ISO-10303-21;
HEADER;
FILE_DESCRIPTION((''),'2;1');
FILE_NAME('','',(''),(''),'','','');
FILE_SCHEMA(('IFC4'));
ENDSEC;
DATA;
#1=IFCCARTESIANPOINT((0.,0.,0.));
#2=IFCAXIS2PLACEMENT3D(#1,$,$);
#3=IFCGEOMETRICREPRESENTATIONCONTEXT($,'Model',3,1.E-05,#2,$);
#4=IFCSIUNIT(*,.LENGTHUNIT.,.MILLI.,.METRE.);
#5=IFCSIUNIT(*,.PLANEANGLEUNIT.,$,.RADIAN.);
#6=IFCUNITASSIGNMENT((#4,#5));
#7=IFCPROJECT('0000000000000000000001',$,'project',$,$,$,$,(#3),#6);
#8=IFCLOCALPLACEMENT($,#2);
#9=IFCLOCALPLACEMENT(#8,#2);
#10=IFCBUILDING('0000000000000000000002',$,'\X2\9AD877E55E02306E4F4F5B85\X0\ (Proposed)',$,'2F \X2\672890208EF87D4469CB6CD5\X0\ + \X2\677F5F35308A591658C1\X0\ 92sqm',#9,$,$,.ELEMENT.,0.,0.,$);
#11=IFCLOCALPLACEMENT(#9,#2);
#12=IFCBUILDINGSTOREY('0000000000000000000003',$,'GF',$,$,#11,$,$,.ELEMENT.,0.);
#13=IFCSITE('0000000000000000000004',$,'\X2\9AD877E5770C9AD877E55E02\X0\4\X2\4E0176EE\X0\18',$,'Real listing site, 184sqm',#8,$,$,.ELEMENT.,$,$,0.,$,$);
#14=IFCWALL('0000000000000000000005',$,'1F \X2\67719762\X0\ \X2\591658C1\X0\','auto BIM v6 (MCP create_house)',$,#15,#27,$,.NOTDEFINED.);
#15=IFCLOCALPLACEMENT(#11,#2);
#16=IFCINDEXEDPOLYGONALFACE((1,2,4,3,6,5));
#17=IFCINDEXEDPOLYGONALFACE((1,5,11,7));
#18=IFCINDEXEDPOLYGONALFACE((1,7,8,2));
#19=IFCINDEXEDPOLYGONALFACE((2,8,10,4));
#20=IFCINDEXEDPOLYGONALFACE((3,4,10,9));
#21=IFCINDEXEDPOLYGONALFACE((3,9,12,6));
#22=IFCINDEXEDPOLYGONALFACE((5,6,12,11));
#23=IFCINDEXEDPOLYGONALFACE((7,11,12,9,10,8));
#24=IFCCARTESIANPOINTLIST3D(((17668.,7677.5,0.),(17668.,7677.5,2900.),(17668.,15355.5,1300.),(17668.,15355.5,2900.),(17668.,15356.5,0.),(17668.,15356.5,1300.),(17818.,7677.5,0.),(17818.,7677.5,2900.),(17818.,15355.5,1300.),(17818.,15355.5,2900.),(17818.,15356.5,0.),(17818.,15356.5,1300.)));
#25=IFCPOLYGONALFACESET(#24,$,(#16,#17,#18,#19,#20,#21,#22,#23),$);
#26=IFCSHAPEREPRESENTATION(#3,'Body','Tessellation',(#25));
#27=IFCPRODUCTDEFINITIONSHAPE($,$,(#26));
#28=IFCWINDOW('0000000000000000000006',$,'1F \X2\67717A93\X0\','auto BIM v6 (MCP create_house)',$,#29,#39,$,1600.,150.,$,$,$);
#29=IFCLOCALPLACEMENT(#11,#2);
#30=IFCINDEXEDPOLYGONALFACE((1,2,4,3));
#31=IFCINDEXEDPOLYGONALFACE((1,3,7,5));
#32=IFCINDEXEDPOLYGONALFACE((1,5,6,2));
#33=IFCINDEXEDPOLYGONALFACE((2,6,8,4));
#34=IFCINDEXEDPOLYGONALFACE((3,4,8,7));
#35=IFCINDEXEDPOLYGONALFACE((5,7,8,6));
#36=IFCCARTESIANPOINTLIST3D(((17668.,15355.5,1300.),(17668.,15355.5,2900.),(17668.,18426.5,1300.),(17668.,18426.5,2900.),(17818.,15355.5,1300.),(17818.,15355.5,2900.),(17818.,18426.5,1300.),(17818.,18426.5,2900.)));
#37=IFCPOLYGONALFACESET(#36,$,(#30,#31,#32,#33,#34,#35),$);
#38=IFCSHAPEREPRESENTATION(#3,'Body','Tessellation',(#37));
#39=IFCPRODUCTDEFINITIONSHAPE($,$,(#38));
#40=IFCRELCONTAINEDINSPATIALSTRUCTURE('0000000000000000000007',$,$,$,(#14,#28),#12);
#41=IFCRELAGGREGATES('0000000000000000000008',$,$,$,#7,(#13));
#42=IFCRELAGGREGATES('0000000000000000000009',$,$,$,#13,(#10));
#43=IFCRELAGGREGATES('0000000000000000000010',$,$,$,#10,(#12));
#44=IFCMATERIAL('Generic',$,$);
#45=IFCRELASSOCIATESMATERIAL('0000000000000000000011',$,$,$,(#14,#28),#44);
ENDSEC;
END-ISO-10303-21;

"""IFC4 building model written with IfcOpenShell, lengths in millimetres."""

from ifc_helpers import new_model, si_unit, frame, frame_2d, origin, place, context, project, spatial, rectangle, extrude, material, element, fill, save


model = new_model("IFC4")

# Units and contexts
model_context = context("Model", 3, precision=1e-05, world=origin())
ifc_project = project(units=[si_unit("LENGTHUNIT", "METRE", prefix="MILLI"), si_unit("PLANEANGLEUNIT", "RADIAN")], contexts=[model_context])

# Site, building, storey
site_placement = place(None, origin())
site = spatial("IfcSite", under=ifc_project, at=site_placement, Name="高知県高知市4丁目18", ObjectType="Real listing site, 184sqm", CompositionType="ELEMENT", RefElevation=0.0)
building_placement = place(site_placement, origin())
building = spatial("IfcBuilding", under=site, at=building_placement, Name="高知市の住宅 (Proposed)", ObjectType="2F 木造軸組構法 + 板張り外壁 92sqm", CompositionType="ELEMENT", ElevationOfRefHeight=0.0, ElevationOfTerrain=0.0)
storey_placement = place(building_placement, origin())
storey = spatial("IfcBuildingStorey", under=building, at=storey_placement, Name="GF", CompositionType="ELEMENT", Elevation=0.0)

# Shared definitions
ifc_material = material(Name="Generic")

# Wall, opening, window
wall_1_placement = place(storey_placement, frame((8834.0, 3839.0, 0.0)))
wall_1 = element("IfcWall", 1, at=wall_1_placement, inside=storey, material=ifc_material, Name="1F 東面 外壁", Description="auto BIM v6 (MCP create_house)", PredefinedType="NOTDEFINED", context=model_context, shape_type="SweptSolid", body=[
    extrude(rectangle(XDim=150.0, YDim=7679.0, at=frame_2d((75.0, 3839.0))), frame((8834.0, 3839.0, 0.0)), (0.0, 0.0, 1.0), 2900.0),
])
opening_1_placement = place(storey_placement, frame((8834.0, 7678.0, 650.0)))
opening_1 = element("IfcOpeningElement", 2, at=opening_1_placement, cuts=wall_1, PredefinedType="NOTDEFINED", context=model_context, shape_type="SweptSolid", body=[
    extrude(rectangle(XDim=150.0, YDim=3071.0, at=frame_2d((75.0, 1535.0))), frame((8834.0, 7678.0, 650.0)), (0.0, 0.0, 1.0), 1600.0),
])
window_1_placement = place(storey_placement, frame((8834.0, 7678.0, 650.0)))
window_1 = element("IfcWindow", 3, at=window_1_placement, inside=storey, material=ifc_material, Name="1F 東窓", Description="auto BIM v6 (MCP create_house)", OverallHeight=1600.0, OverallWidth=150.0, context=model_context, shape_type="SweptSolid", body=[
    extrude(rectangle(XDim=150.0, YDim=3071.0, at=frame_2d((75.0, 1535.0))), frame((8834.0, 7678.0, 650.0)), (0.0, 0.0, 1.0), 1600.0),
])
fill(opening_1, window_1)

save(model, "model.ifc")
